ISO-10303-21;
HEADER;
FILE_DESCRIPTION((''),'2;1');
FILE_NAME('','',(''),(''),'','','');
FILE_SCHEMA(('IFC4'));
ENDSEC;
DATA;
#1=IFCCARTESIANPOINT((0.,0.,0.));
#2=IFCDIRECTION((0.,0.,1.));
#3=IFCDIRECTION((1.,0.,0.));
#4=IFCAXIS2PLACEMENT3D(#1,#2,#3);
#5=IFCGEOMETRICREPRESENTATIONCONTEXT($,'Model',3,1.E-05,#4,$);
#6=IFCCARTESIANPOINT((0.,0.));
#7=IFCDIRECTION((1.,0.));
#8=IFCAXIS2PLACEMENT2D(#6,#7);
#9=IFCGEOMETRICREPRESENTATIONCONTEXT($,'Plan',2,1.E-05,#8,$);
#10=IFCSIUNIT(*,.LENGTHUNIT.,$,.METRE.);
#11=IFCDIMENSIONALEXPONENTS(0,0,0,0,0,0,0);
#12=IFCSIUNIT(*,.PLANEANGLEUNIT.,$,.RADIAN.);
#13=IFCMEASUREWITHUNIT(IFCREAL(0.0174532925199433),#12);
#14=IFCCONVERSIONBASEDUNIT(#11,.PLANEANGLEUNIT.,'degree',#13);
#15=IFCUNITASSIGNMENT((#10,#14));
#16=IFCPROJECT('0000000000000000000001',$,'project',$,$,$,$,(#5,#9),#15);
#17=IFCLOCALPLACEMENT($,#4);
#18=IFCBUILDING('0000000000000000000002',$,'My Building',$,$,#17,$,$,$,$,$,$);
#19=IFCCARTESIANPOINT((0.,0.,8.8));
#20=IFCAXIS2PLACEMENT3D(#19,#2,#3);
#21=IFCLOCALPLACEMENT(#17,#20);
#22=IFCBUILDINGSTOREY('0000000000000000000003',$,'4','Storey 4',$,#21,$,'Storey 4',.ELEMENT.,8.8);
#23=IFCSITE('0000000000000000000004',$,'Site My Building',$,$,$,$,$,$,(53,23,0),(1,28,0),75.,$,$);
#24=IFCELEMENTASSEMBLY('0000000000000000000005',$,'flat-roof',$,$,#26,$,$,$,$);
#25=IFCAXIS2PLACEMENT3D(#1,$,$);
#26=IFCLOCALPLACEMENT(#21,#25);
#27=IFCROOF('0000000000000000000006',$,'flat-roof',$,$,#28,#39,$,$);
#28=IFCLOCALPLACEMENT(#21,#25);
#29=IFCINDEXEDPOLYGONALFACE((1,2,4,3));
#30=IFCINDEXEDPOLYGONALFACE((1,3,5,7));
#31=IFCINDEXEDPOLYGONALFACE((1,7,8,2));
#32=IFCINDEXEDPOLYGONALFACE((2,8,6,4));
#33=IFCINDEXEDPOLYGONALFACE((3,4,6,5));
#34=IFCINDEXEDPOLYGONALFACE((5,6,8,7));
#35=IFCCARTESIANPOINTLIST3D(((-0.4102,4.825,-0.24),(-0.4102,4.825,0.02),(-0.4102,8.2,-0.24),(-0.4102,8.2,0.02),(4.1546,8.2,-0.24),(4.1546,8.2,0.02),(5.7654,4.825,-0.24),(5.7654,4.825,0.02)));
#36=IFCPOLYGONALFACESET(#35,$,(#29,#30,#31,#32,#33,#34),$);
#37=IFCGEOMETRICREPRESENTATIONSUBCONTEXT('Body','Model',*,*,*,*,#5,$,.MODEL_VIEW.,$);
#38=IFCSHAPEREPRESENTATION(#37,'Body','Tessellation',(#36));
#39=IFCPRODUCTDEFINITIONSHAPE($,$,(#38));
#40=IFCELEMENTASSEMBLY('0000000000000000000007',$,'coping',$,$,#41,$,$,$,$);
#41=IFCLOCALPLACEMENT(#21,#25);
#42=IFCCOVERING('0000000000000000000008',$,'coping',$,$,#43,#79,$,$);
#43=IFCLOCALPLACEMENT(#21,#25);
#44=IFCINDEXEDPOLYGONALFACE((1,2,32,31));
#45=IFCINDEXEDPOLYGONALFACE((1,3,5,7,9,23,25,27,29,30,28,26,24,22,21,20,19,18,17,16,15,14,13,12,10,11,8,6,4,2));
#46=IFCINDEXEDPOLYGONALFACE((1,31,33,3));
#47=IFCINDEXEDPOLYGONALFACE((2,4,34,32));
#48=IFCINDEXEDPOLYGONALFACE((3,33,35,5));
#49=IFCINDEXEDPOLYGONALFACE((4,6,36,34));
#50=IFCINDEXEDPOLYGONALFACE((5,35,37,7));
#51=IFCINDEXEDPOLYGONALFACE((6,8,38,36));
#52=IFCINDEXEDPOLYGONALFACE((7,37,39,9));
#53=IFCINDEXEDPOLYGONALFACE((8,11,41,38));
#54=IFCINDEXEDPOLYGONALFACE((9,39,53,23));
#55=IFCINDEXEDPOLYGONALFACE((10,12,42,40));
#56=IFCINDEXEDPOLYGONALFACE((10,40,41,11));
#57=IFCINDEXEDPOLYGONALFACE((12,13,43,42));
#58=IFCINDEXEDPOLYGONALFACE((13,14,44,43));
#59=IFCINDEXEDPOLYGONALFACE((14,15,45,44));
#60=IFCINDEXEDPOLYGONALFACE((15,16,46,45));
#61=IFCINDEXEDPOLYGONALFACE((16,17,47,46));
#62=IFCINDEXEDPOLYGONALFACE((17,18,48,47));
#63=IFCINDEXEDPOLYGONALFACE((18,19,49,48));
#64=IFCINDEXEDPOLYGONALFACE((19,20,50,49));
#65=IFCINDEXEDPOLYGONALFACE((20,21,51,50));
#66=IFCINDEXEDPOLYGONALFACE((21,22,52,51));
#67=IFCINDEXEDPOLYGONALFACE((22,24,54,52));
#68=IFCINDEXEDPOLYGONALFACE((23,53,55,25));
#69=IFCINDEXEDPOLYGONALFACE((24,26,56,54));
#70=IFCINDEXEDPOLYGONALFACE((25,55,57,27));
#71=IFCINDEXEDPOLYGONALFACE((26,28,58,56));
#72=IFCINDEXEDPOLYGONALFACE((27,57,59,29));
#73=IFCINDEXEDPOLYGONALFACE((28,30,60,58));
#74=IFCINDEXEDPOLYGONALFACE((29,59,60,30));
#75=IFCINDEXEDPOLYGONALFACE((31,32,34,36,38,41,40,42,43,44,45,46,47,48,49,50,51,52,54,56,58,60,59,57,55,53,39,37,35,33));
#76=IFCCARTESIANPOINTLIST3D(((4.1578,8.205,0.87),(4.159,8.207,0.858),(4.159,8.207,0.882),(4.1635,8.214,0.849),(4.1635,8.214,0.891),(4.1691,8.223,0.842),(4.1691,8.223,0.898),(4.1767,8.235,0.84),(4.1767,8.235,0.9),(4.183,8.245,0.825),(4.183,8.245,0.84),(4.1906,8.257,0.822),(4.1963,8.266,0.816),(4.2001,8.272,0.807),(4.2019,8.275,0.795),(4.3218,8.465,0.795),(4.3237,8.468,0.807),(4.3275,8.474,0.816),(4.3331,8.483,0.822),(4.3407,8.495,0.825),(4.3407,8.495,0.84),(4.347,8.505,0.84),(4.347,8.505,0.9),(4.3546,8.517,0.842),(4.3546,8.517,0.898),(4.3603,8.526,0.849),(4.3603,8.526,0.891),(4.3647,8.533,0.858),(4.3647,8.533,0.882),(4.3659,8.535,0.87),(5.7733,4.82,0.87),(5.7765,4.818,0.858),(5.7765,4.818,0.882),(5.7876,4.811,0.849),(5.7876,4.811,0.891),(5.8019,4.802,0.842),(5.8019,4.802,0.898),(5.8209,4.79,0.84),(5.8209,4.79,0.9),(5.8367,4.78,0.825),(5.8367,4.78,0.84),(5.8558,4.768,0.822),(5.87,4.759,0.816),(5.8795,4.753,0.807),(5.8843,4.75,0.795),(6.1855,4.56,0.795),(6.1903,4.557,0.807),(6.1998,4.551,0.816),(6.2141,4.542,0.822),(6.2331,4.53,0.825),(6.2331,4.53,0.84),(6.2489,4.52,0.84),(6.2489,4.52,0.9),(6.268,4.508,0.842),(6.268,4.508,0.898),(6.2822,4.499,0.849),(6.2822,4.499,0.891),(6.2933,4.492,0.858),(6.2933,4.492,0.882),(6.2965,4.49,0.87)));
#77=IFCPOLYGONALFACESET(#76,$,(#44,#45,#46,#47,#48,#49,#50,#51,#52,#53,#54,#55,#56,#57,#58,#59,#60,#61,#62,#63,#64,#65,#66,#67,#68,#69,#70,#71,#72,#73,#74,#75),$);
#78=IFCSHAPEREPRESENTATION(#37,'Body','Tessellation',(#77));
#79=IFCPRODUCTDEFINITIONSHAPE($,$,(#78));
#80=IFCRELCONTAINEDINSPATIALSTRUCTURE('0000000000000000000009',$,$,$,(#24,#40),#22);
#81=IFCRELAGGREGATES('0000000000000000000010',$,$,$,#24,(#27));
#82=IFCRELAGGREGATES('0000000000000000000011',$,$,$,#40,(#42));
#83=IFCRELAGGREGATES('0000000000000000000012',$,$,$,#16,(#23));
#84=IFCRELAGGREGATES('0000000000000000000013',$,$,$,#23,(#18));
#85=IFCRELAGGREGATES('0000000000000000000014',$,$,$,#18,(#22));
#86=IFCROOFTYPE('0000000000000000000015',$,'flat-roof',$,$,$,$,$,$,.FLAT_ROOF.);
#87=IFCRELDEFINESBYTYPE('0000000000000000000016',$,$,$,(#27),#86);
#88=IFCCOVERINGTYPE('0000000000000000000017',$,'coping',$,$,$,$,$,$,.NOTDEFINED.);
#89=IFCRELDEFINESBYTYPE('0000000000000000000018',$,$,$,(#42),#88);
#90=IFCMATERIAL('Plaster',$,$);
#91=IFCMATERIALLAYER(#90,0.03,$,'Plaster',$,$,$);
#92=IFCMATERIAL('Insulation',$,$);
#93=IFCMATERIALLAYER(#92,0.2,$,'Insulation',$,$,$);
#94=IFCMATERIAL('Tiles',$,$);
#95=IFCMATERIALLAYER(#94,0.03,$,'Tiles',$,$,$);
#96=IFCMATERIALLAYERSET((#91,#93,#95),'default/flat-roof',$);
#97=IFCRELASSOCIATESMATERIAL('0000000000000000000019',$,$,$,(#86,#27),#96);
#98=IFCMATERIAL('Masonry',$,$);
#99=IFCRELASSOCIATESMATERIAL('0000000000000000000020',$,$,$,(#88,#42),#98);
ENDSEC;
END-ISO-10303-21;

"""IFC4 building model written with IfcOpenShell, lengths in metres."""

from ifc_helpers import new_model, entity, si_unit, converted_unit, frame, origin, origin_with_axes, origin_2d_with_axis, place, context, subcontext, project, spatial, polyline, outline, extrude, clip, halfspace, material, layer, layer_set, layer_usage, material_profile, profile_set, profile_usage, type_object, element, aggregate, save


model = new_model("IFC4")

# Units and contexts
model_context = context("Model", 3, precision=1e-05, world=origin_with_axes())
plan_context = context("Plan", 2, precision=1e-05, world=origin_2d_with_axis())
body_context = subcontext(model_context, "Body", "Model", "MODEL_VIEW")
ifc_project = project(units=[si_unit("LENGTHUNIT", "METRE"), converted_unit("PLANEANGLEUNIT", "degree", entity("IfcReal", 0.0174532925199433), si_unit("PLANEANGLEUNIT", "RADIAN"), dimensions=[0, 0, 0, 0, 0, 0, 0])], contexts=[model_context, plan_context])

# Site, building, storey
site = spatial("IfcSite", under=ifc_project, Name="Site My Building", RefLatitude=(53, 23, 0), RefLongitude=(1, 28, 0), RefElevation=75.0)
building_placement = place(None, origin_with_axes())
building = spatial("IfcBuilding", under=site, at=building_placement, Name="My Building")
storey_placement = place(building_placement, frame((0.0, 0.0, 8.8), z_axis=(0.0, 0.0, 1.0), x_axis=(1.0, 0.0, 0.0)))
storey = spatial("IfcBuildingStorey", under=building, at=storey_placement, Name="4", Description="Storey 4", LongName="Storey 4", CompositionType="ELEMENT", Elevation=8.8)

# Shared definitions
ifc_material_1 = material(Name="Masonry")

# Element assembly, roof
assembly_1_placement = place(storey_placement, frame((0.0, 0.0, -8.8), z_axis=(0.0, 0.0, 1.0), x_axis=(1.0, 0.0, 0.0)))
assembly_1 = element("IfcElementAssembly", 1, at=assembly_1_placement, inside=storey, Name="flat-roof")
ifc_material_2 = material(Name="Plaster")
ifc_layer_1 = layer(ifc_material_2, 0.03, Name="Plaster")
ifc_material_3 = material(Name="Insulation")
ifc_layer_2 = layer(ifc_material_3, 0.2, Name="Insulation")
ifc_material_4 = material(Name="Tiles")
ifc_layer_3 = layer(ifc_material_4, 0.03, Name="Tiles")
ifc_layer_set = layer_set([ifc_layer_1, ifc_layer_2, ifc_layer_3], Name="default/flat-roof")
ifc_layer_usage = layer_usage(ifc_layer_set, "AXIS3", "POSITIVE", 0.0)
roof_type = type_object("IfcRoofType", Name="flat-roof", PredefinedType="FLAT_ROOF", material=ifc_layer_set)
roof_placement = place(assembly_1_placement, frame((4.1546, 8.2, 8.56), z_axis=(0.0, 0.0, 1.0), x_axis=(1.0, 0.0, 0.0)))
roof = element("IfcRoof", 2, at=roof_placement, type_object=roof_type, material=ifc_layer_usage, Name="flat-roof", context=body_context, shape_type="SweptSolid", body=[
    extrude(outline(polyline([(0.0, 0.0), (1.6108, -3.375), (-4.5648, -3.375), (-4.5648, 0.0), (0.0, 0.0)])), origin(), (0.0, 0.0, 1.0), 0.26),
])
aggregate(assembly_1, [roof])

# Element assembly, covering
assembly_2_placement = place(storey_placement, frame((0.0, 0.0, -8.8), z_axis=(0.0, 0.0, 1.0), x_axis=(1.0, 0.0, 0.0)))
assembly_2 = element("IfcElementAssembly", 3, at=assembly_2_placement, inside=storey, Name="coping")
ifc_material_profile_1 = material_profile(ifc_material_1, outline(polyline([(0.265, 0.795), (0.268, 0.807), (0.274, 0.816), (0.283, 0.822), (0.295, 0.825), (0.295, 0.84), (0.305, 0.84), (0.317, 0.842), (0.326, 0.849), (0.333, 0.858), (0.335, 0.87), (0.333, 0.882), (0.326, 0.891), (0.317, 0.898), (0.305, 0.9), (0.035, 0.9), (0.023, 0.898), (0.014, 0.891), (0.007, 0.882), (0.005, 0.87), (0.007, 0.858), (0.014, 0.849), (0.023, 0.842), (0.035, 0.84), (0.045, 0.84), (0.045, 0.825), (0.057, 0.822), (0.066, 0.816), (0.072, 0.807), (0.075, 0.795), (0.265, 0.795)])))
ifc_profile_set_1 = profile_set([ifc_material_profile_1])
covering_type_1 = type_object("IfcCoveringType", Name="coping", PredefinedType="NOTDEFINED", material=ifc_profile_set_1)
ifc_profile_usage_1 = profile_usage(ifc_profile_set_1)
covering_1_placement = place(assembly_2_placement, frame((3.7239, 9.1025, 8.8), z_axis=(0.430724, -0.902484, 0.0), x_axis=(0.902484, 0.430724, 0.0)))
covering_1 = element("IfcCovering", 4, at=covering_1_placement, type_object=covering_type_1, material=ifc_profile_usage_1, Name="coping", context=body_context, shape_type="Clipping", body=[
    clip(clip(extrude(outline(polyline([(0.265, 0.795), (0.268, 0.807), (0.274, 0.816), (0.283, 0.822), (0.295, 0.825), (0.295, 0.84), (0.305, 0.84), (0.317, 0.842), (0.326, 0.849), (0.333, 0.858), (0.335, 0.87), (0.333, 0.882), (0.326, 0.891), (0.317, 0.898), (0.305, 0.9), (0.035, 0.9), (0.023, 0.898), (0.014, 0.891), (0.007, 0.882), (0.005, 0.87), (0.007, 0.858), (0.014, 0.849), (0.023, 0.842), (0.035, 0.84), (0.045, 0.84), (0.045, 0.825), (0.057, 0.822), (0.066, 0.816), (0.072, 0.807), (0.075, 0.795), (0.265, 0.795)])), origin_with_axes(), (0.0, 0.0, 1.0), 5.7397), halfspace(frame((0.0, -8.8, 1.0), z_axis=(-0.533515, 0.0, -0.845791), x_axis=(0.0, 1.0, 0.0)), False)), halfspace(frame((0.0, -8.8, 4.7397), z_axis=(-0.845791, 0.0, 0.533515), x_axis=(0.0, 1.0, 0.0)), False)),
])
aggregate(assembly_2, [covering_1])

save(model, "model.ifc")
